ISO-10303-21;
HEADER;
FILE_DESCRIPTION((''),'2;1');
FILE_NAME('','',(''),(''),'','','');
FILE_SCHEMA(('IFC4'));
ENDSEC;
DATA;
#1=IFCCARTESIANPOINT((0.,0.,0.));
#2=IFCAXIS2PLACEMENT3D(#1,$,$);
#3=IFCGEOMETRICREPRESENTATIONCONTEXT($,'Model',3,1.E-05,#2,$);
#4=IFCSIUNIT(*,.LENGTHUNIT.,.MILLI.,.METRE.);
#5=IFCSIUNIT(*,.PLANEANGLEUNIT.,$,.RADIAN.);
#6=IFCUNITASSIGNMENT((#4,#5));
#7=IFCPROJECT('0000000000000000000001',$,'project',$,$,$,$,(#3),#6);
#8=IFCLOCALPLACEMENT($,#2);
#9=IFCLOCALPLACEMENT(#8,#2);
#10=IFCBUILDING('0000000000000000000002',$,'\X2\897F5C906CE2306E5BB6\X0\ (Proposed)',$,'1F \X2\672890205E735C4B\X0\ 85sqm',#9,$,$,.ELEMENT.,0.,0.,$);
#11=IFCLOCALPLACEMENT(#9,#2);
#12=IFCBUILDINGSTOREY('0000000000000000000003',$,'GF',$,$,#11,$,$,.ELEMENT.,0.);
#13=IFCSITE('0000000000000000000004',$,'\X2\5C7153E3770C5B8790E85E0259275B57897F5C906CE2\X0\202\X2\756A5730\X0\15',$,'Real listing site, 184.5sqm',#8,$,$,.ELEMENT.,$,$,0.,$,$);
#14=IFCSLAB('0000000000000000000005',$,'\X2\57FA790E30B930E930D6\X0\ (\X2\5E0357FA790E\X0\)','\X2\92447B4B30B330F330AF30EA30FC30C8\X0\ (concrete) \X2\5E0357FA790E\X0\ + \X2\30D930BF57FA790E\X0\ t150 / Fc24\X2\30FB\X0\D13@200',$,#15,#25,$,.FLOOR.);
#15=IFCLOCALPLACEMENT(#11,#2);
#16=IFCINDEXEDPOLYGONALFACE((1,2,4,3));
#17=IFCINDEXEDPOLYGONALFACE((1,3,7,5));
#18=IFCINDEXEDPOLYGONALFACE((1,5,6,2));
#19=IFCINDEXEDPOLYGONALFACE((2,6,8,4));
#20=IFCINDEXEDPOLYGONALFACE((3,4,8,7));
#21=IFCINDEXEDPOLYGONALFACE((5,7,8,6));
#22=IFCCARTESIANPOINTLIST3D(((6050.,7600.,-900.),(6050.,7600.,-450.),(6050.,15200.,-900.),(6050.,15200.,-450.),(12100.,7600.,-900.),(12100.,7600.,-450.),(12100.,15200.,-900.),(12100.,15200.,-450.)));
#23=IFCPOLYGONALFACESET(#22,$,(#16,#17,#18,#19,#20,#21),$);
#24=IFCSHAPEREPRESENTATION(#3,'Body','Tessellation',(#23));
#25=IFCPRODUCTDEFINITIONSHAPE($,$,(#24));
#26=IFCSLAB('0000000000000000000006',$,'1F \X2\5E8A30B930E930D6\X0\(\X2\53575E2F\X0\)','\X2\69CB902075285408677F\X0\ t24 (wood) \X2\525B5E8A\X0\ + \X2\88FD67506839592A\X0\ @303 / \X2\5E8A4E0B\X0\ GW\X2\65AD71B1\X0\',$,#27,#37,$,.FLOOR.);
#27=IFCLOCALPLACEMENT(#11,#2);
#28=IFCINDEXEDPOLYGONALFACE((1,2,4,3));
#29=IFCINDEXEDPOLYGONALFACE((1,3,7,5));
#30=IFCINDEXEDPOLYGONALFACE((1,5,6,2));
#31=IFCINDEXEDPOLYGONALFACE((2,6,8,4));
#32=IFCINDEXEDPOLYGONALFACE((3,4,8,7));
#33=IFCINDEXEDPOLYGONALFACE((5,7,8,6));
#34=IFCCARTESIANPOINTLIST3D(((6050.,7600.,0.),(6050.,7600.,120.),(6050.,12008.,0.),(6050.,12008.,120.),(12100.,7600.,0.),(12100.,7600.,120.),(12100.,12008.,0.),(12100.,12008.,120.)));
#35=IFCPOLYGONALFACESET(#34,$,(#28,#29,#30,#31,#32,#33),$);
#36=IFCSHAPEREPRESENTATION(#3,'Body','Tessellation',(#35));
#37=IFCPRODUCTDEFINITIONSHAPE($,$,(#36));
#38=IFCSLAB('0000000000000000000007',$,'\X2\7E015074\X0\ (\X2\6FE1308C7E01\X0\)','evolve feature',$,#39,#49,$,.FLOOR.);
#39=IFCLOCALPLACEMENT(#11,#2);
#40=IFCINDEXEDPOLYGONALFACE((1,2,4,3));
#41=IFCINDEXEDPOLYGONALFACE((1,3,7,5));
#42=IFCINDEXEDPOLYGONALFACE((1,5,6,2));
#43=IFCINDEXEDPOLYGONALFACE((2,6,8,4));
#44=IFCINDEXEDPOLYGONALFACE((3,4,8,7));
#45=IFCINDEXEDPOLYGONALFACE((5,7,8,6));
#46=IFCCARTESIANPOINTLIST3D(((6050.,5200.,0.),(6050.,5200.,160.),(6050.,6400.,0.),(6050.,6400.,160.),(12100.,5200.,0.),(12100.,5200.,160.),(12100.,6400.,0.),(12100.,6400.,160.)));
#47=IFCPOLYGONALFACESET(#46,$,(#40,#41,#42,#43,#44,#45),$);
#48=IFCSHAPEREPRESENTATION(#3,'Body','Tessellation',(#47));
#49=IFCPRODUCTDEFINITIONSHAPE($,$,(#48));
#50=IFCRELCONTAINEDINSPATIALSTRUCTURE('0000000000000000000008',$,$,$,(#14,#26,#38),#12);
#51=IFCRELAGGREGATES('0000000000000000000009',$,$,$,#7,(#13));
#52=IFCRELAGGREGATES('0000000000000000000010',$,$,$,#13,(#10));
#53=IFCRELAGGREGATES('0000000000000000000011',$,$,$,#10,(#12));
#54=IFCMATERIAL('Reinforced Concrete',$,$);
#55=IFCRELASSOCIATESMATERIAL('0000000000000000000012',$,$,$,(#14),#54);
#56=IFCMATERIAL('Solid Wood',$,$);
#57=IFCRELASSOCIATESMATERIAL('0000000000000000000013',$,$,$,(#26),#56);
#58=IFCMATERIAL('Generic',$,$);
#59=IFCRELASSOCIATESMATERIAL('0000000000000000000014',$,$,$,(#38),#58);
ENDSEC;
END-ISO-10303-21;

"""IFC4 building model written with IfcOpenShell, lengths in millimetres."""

from ifc_helpers import new_model, si_unit, frame, frame_2d, origin, place, context, project, spatial, rectangle, extrude, material, element, save


model = new_model("IFC4")

# Units and contexts
model_context = context("Model", 3, precision=1e-05, world=origin())
ifc_project = project(units=[si_unit("LENGTHUNIT", "METRE", prefix="MILLI"), si_unit("PLANEANGLEUNIT", "RADIAN")], contexts=[model_context])

# Site, building, storey
site_placement = place(None, origin())
site = spatial("IfcSite", under=ifc_project, at=site_placement, Name="山口県宇部市大字西岐波202番地15", ObjectType="Real listing site, 184.5sqm", CompositionType="ELEMENT", RefElevation=0.0)
building_placement = place(site_placement, origin())
building = spatial("IfcBuilding", under=site, at=building_placement, Name="西岐波の家 (Proposed)", ObjectType="1F 木造平屋 85sqm", CompositionType="ELEMENT", ElevationOfRefHeight=0.0, ElevationOfTerrain=0.0)
storey_placement = place(building_placement, origin())
storey = spatial("IfcBuildingStorey", under=building, at=storey_placement, Name="GF", CompositionType="ELEMENT", Elevation=0.0)

# Slabs
ifc_material_1 = material(Name="Reinforced Concrete")
slab_1_placement = place(storey_placement, frame((3025.0, 3800.0, -450.0)))
element("IfcSlab", 1, at=slab_1_placement, inside=storey, material=ifc_material_1, Name="基礎スラブ (布基礎)", Description="鉄筋コンクリート (concrete) 布基礎 + ベタ基礎 t150 / Fc24・D13@200", PredefinedType="FLOOR", context=model_context, shape_type="SweptSolid", body=[
    extrude(rectangle(XDim=6050.0, YDim=7600.0, at=frame_2d((3025.0, 3800.0))), frame((3025.0, 3800.0, -450.0)), (0.0, 0.0, 1.0), 450.0),
])
ifc_material_2 = material(Name="Solid Wood")
slab_2_placement = place(storey_placement, frame((3025.0, 3800.0, 0.0)))
element("IfcSlab", 2, at=slab_2_placement, inside=storey, material=ifc_material_2, Name="1F 床スラブ(南帯)", Description="構造用合板 t24 (wood) 剛床 + 製材根太 @303 / 床下 GW断熱", PredefinedType="FLOOR", context=model_context, shape_type="SweptSolid", body=[
    extrude(rectangle(XDim=6050.0, YDim=4408.0, at=frame_2d((3025.0, 2204.0))), frame((3025.0, 3800.0, 0.0)), (0.0, 0.0, 1.0), 120.0),
])
ifc_material_3 = material(Name="Generic")
slab_3_placement = place(storey_placement, frame((3025.0, 2600.0, 0.0)))
element("IfcSlab", 3, at=slab_3_placement, inside=storey, material=ifc_material_3, Name="縁側 (濡れ縁)", Description="evolve feature", PredefinedType="FLOOR", context=model_context, shape_type="SweptSolid", body=[
    extrude(rectangle(XDim=6050.0, YDim=1200.0, at=frame_2d((3025.0, 600.0))), frame((3025.0, 2600.0, 0.0)), (0.0, 0.0, 1.0), 160.0),
])

save(model, "model.ifc")
